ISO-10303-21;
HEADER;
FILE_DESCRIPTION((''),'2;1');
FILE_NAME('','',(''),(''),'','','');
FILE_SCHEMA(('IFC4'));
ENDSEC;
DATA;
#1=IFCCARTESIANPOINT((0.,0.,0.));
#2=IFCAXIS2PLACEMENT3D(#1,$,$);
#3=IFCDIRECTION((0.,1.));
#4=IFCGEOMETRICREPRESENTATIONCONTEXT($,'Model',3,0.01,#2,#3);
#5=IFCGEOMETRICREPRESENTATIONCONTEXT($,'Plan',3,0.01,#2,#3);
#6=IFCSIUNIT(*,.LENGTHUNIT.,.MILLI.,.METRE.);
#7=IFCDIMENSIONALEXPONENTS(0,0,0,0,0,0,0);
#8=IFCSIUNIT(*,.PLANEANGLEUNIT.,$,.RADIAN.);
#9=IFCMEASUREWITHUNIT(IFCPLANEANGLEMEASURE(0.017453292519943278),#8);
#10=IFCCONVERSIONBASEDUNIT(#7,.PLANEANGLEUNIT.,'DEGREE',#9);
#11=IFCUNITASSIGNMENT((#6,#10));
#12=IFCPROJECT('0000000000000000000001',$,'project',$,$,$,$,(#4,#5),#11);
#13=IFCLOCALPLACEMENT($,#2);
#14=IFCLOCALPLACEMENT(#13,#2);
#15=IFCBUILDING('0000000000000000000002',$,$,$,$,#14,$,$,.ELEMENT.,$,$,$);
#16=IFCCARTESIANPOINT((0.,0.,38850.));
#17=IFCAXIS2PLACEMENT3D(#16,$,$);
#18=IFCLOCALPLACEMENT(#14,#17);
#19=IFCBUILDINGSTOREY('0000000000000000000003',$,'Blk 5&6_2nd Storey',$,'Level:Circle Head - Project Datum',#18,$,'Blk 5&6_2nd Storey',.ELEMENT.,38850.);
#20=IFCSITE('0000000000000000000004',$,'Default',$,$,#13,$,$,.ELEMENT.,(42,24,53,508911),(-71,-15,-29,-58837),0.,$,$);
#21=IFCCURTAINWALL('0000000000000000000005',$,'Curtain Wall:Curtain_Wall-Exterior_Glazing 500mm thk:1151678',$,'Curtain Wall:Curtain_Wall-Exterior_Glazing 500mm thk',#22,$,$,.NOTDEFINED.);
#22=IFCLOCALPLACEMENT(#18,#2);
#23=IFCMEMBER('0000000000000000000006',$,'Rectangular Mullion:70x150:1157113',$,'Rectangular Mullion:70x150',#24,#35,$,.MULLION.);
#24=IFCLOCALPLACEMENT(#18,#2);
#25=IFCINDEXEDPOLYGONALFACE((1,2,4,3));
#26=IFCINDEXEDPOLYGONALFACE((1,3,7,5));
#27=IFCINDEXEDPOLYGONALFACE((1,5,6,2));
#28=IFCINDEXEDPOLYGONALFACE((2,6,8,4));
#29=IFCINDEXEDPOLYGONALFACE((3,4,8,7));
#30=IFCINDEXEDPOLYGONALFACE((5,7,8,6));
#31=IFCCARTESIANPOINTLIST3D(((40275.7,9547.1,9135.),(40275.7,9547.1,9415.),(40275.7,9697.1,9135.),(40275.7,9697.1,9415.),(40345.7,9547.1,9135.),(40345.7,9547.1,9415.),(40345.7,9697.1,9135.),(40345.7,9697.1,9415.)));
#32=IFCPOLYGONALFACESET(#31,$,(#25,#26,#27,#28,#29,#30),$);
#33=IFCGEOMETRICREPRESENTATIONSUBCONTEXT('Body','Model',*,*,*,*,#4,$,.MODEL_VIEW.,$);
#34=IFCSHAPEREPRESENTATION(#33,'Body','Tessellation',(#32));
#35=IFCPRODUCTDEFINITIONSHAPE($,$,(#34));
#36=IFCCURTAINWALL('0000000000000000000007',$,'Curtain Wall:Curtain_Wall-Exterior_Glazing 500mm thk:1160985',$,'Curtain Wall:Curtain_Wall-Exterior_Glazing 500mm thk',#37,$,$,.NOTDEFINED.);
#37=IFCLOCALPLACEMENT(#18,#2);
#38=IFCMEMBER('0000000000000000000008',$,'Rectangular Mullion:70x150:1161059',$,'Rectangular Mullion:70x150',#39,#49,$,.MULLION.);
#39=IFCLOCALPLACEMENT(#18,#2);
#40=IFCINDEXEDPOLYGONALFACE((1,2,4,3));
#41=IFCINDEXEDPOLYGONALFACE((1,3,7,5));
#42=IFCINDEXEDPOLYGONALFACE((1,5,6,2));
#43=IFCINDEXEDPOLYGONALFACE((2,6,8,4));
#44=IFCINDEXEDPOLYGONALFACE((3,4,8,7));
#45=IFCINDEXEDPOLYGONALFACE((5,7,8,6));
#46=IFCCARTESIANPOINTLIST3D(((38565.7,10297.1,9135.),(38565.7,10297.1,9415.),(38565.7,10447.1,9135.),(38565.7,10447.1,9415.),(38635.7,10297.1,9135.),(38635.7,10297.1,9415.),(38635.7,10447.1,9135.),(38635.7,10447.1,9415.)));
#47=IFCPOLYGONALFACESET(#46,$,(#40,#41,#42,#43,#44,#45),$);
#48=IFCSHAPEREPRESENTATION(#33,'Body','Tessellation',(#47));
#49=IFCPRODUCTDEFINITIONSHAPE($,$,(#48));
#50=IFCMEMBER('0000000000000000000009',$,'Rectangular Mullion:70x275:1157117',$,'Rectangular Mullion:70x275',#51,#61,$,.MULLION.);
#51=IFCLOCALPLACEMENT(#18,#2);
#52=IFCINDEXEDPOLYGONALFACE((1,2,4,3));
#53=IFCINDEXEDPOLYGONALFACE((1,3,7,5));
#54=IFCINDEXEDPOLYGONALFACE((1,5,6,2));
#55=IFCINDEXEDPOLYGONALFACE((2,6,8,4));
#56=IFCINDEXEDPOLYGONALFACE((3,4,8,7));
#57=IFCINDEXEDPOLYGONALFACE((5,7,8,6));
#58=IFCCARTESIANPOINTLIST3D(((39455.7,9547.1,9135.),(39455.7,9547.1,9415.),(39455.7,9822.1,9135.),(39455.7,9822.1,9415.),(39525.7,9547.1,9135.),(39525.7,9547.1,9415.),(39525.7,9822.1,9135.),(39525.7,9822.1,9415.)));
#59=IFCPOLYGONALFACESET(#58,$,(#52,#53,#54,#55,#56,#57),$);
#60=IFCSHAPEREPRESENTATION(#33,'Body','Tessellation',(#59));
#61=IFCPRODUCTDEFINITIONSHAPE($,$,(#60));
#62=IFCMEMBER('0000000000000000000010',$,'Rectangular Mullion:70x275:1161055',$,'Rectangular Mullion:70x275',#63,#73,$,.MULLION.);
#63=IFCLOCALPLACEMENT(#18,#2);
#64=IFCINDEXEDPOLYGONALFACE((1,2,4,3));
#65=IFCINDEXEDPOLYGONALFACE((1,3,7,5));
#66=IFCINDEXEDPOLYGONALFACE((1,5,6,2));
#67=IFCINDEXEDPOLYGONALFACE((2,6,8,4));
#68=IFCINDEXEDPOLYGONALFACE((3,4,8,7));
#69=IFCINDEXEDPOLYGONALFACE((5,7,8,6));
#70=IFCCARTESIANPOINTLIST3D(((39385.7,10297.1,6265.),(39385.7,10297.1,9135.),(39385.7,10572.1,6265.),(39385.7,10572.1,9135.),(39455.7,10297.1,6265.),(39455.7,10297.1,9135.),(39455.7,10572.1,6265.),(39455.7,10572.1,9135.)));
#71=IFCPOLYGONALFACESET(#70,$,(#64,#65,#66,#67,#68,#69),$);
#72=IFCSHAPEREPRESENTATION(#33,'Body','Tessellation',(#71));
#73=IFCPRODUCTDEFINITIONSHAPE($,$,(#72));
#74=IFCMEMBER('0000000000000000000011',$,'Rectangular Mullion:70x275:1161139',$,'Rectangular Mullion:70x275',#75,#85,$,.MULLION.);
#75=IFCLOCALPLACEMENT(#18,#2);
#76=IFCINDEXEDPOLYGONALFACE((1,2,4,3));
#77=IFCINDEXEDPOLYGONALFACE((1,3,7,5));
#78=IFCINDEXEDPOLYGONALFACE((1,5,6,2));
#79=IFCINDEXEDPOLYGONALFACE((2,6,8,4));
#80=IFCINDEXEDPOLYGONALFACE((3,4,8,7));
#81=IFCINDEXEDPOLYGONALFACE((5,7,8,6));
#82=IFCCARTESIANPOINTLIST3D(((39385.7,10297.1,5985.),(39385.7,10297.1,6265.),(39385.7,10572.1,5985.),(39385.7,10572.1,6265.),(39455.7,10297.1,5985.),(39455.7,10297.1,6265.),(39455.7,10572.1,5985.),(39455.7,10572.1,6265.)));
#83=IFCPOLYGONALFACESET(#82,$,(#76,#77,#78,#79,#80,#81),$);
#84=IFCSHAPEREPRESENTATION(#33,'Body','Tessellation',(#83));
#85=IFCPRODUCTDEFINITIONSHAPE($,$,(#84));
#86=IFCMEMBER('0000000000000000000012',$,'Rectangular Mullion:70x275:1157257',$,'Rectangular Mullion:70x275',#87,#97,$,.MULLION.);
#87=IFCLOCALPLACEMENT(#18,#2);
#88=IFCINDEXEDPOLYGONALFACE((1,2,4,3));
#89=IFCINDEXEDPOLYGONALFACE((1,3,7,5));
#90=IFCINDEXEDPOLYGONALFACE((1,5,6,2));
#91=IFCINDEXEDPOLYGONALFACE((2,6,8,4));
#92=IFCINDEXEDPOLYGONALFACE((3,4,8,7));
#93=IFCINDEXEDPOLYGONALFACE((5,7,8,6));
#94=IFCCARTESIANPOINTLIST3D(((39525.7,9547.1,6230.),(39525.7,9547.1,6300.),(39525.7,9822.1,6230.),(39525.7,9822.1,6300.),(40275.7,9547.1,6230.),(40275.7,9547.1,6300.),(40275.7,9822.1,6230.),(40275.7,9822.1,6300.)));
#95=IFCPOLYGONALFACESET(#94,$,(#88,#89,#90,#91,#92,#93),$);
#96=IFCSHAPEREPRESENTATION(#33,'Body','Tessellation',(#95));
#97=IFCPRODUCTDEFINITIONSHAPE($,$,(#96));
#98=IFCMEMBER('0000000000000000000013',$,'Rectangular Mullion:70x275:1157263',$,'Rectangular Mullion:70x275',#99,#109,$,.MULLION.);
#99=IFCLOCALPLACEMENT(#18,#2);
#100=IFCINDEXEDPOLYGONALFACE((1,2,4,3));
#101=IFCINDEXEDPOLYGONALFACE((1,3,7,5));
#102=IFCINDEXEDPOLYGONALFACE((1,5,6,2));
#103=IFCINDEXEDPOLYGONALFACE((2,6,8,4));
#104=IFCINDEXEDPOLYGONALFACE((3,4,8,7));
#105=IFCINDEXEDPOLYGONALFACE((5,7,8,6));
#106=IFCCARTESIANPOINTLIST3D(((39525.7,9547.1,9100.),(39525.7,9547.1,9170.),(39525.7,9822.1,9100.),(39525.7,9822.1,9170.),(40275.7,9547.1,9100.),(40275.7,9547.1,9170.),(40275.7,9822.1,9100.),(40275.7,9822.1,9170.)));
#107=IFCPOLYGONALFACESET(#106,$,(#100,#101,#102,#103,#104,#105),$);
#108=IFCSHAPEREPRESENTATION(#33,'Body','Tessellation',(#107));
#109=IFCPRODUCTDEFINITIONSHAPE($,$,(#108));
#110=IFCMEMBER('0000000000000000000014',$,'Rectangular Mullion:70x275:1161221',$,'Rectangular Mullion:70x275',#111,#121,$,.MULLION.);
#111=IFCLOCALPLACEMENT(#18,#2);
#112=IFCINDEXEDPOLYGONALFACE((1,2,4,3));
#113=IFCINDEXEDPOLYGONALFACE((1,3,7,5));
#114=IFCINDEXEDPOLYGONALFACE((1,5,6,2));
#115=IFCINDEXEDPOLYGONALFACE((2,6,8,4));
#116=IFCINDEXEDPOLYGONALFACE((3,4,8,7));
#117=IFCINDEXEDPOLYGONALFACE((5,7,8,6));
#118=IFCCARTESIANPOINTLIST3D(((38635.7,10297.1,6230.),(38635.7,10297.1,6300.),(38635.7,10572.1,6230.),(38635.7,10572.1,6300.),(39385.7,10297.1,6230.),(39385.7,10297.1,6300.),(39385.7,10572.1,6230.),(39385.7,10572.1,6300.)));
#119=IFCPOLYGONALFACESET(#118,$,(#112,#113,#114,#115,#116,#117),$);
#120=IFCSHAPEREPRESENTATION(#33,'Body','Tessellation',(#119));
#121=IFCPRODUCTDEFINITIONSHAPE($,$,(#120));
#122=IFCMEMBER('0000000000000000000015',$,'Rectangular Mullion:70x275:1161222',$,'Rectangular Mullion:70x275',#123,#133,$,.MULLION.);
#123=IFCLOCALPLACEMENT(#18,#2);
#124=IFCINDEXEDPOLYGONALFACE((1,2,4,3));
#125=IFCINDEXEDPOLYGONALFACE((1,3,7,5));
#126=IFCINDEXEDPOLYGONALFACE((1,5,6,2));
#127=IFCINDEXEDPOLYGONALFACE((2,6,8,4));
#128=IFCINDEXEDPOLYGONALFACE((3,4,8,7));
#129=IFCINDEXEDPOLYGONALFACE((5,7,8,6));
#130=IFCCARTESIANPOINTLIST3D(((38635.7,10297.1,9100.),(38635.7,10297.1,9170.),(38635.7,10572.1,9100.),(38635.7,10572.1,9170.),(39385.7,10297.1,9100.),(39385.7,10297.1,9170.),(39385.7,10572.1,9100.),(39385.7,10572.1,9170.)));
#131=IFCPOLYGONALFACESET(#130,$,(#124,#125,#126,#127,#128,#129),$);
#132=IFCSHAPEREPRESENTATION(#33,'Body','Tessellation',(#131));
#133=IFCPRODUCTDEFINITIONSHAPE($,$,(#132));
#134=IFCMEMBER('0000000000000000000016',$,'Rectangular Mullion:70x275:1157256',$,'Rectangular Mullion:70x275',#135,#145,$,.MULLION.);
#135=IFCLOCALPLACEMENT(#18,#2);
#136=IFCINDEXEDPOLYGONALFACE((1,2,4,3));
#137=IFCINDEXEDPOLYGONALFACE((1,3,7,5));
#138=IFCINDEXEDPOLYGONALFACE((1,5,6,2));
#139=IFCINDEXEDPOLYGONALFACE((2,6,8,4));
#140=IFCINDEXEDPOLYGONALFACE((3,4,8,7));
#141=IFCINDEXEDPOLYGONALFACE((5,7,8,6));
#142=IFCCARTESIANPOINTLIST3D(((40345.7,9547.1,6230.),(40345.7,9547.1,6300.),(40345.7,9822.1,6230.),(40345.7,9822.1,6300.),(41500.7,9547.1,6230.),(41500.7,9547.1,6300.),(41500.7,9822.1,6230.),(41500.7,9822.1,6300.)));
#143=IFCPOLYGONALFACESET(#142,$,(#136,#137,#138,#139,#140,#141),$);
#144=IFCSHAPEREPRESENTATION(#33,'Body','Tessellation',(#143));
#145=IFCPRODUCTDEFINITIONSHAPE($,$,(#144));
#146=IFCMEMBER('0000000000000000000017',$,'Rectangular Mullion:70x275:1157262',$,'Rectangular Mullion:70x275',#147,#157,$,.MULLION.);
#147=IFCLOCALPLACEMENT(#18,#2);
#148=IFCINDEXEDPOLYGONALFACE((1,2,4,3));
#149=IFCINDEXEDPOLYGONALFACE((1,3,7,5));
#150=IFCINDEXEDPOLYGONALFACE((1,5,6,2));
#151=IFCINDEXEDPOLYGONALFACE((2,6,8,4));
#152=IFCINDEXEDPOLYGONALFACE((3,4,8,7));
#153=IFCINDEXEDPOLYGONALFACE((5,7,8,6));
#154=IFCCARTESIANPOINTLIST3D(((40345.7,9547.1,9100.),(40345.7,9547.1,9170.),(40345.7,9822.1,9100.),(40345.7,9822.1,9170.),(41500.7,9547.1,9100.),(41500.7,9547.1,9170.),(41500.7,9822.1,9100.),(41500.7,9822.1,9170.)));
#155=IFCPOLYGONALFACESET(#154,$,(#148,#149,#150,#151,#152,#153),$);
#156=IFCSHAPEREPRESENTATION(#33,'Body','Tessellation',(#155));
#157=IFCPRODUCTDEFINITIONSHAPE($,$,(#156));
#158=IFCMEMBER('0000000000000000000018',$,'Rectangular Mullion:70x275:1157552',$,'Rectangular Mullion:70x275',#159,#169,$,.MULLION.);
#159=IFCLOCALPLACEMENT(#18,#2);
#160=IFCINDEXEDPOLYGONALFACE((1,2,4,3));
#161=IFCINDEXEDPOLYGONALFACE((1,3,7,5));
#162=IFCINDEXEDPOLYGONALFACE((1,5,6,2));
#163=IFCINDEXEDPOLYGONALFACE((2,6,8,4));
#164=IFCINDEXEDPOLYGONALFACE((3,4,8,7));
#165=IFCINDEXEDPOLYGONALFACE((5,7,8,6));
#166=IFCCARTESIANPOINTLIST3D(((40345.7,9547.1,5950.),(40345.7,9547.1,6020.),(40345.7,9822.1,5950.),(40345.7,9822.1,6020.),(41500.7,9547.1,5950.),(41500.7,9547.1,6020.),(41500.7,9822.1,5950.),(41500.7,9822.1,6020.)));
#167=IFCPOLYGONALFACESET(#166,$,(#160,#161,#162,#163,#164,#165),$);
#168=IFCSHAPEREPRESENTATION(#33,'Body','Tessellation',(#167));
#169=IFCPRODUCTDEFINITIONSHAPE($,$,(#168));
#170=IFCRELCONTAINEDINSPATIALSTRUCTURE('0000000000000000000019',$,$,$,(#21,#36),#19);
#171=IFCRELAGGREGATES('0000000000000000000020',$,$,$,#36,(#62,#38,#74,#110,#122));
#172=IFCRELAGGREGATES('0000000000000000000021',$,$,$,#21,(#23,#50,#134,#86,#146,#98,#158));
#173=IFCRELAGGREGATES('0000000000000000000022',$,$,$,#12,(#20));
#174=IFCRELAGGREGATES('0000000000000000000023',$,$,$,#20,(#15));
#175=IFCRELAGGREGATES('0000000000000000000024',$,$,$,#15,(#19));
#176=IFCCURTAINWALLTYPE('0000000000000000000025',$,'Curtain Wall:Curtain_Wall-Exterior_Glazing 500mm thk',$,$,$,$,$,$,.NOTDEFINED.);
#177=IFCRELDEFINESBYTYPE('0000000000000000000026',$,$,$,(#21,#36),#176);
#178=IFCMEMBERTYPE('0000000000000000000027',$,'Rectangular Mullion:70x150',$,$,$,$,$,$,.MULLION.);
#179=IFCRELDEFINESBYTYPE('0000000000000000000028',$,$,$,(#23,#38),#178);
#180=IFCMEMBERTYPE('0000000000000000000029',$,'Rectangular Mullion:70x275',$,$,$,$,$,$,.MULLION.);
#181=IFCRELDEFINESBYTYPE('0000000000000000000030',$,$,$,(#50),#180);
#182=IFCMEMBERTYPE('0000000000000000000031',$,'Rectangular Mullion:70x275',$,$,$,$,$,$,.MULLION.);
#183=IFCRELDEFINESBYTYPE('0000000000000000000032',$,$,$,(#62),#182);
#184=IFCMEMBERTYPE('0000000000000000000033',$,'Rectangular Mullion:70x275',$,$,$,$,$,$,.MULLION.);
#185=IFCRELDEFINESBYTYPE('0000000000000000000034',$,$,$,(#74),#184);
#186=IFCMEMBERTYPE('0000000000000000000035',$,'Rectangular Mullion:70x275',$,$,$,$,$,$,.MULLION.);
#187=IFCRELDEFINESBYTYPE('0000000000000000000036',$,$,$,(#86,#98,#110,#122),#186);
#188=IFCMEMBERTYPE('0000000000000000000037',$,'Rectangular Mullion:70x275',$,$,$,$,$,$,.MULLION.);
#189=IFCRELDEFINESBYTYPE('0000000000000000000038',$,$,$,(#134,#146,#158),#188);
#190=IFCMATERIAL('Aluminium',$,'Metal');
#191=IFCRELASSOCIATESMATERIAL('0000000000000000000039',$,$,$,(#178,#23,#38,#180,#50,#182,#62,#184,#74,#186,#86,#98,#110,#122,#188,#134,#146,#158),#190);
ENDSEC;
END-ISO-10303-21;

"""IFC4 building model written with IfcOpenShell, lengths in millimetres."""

from ifc_helpers import new_model, entity, si_unit, converted_unit, direction, frame, origin, place, context, subcontext, project, spatial, indexed_curve, outline, extrude, source, transform, mapped, material, type_object, type_shapes, element, aggregate, save


model = new_model("IFC4")

# Units and contexts
model_context = context("Model", 3, precision=0.01, world=origin(), true_north=direction((0.0, 1.0)))
plan_context = context("Plan", 3, precision=0.01, world=origin(), true_north=direction((0.0, 1.0)))
body_context = subcontext(model_context, "Body", "Model", "MODEL_VIEW")
ifc_project = project(units=[si_unit("LENGTHUNIT", "METRE", prefix="MILLI"), converted_unit("PLANEANGLEUNIT", "DEGREE", entity("IfcPlaneAngleMeasure", 0.017453292519943278), si_unit("PLANEANGLEUNIT", "RADIAN"), dimensions=[0, 0, 0, 0, 0, 0, 0])], contexts=[model_context, plan_context])

# Site, building, storey
site_placement = place(None, origin())
site = spatial("IfcSite", under=ifc_project, at=site_placement, Name="Default", CompositionType="ELEMENT", RefLatitude=(42, 24, 53, 508911), RefLongitude=(-71, -15, -29, -58837), RefElevation=0.0)
building_placement = place(site_placement, origin())
building = spatial("IfcBuilding", under=site, at=building_placement, CompositionType="ELEMENT")
storey_placement = place(building_placement, frame((0.0, 0.0, 38850.0)))
storey = spatial("IfcBuildingStorey", under=building, at=storey_placement, Name="Blk 5&6_2nd Storey", ObjectType="Level:Circle Head - Project Datum", LongName="Blk 5&6_2nd Storey", CompositionType="ELEMENT", Elevation=38850.0)

# Curtain walls, members
curtain_wall_type = type_object("IfcCurtainWallType", Name="Curtain Wall:Curtain_Wall-Exterior_Glazing 500mm thk", PredefinedType="NOTDEFINED")
curtain_wall_1_placement = place(storey_placement, frame((0.0, 0.0, -38850.0)))
curtain_wall_1 = element("IfcCurtainWall", 1, at=curtain_wall_1_placement, inside=storey, type_object=curtain_wall_type, Name="Curtain Wall:Curtain_Wall-Exterior_Glazing 500mm thk:1151678", ObjectType="Curtain Wall:Curtain_Wall-Exterior_Glazing 500mm thk", PredefinedType="NOTDEFINED")
ifc_material_1 = material(Name="Aluminium", Category="Metal")
member_type_1 = type_object("IfcMemberType", Name="Rectangular Mullion:70x150", PredefinedType="MULLION", material=ifc_material_1)
shared_shape_1 = source(origin(), body_context, "Body", "SweptSolid", [
    extrude(outline(indexed_curve([(-35.0, -75.0), (35.0, -75.0), (35.0, 75.0), (-35.0, 75.0), (-35.0, -75.0)], self_intersect=False)), frame((0.0, -200.0, -280.0), z_axis=(0.0, 0.0, 1.0), x_axis=(-1.0, 0.0, 0.0)), (0.0, 0.0, 1.0), 280.0),
])
type_shapes(member_type_1, [shared_shape_1])
member_1_placement = place(curtain_wall_1_placement, frame((40310.7, 9822.1, 47985.0), z_axis=(0.0, 0.0, -1.0), x_axis=(-1.0, 0.0, 0.0)))
member_1 = element("IfcMember", 2, at=member_1_placement, type_object=member_type_1, material=ifc_material_1, Name="Rectangular Mullion:70x150:1157113", ObjectType="Rectangular Mullion:70x150", PredefinedType="MULLION", context=body_context, shape_type="MappedRepresentation", body=[
    mapped(shared_shape_1, transform((0.0, 0.0, 0.0), scale=1.0)),
])
curtain_wall_2_placement = place(storey_placement, frame((0.0, 0.0, -38850.0)))
curtain_wall_2 = element("IfcCurtainWall", 3, at=curtain_wall_2_placement, inside=storey, type_object=curtain_wall_type, Name="Curtain Wall:Curtain_Wall-Exterior_Glazing 500mm thk:1160985", ObjectType="Curtain Wall:Curtain_Wall-Exterior_Glazing 500mm thk", PredefinedType="NOTDEFINED")
member_2_placement = place(curtain_wall_2_placement, frame((38600.7, 10572.1, 47985.0), z_axis=(0.0, 0.0, -1.0), x_axis=(-1.0, 0.0, 0.0)))
member_2 = element("IfcMember", 4, at=member_2_placement, type_object=member_type_1, material=ifc_material_1, Name="Rectangular Mullion:70x150:1161059", ObjectType="Rectangular Mullion:70x150", PredefinedType="MULLION", context=body_context, shape_type="MappedRepresentation", body=[
    mapped(shared_shape_1, transform((0.0, 0.0, 0.0), scale=1.0)),
])

# Members
member_type_2 = type_object("IfcMemberType", Name="Rectangular Mullion:70x275", PredefinedType="MULLION", material=ifc_material_1)
shared_shape_2 = source(origin(), body_context, "Body", "SweptSolid", [
    extrude(outline(indexed_curve([(-35.0, -137.5), (35.0, -137.5), (35.0, 137.5), (-35.0, 137.5), (-35.0, -137.5)], self_intersect=False)), frame((-35.0, -137.5, -280.0), z_axis=(0.0, 0.0, 1.0), x_axis=(-1.0, 0.0, 0.0)), (0.0, 0.0, 1.0), 280.0),
])
type_shapes(member_type_2, [shared_shape_2])
member_3_placement = place(curtain_wall_1_placement, frame((39455.7, 9822.1, 47985.0), z_axis=(0.0, 0.0, -1.0), x_axis=(-1.0, 0.0, 0.0)))
member_3 = element("IfcMember", 5, at=member_3_placement, type_object=member_type_2, material=ifc_material_1, Name="Rectangular Mullion:70x275:1157117", ObjectType="Rectangular Mullion:70x275", PredefinedType="MULLION", context=body_context, shape_type="MappedRepresentation", body=[
    mapped(shared_shape_2, transform((0.0, 0.0, 0.0), scale=1.0)),
])
member_type_3 = type_object("IfcMemberType", Name="Rectangular Mullion:70x275", PredefinedType="MULLION", material=ifc_material_1)
shared_shape_3 = source(origin(), body_context, "Body", "SweptSolid", [
    extrude(outline(indexed_curve([(-35.0, -137.5), (35.0, -137.5), (35.0, 137.5), (-35.0, 137.5), (-35.0, -137.5)], self_intersect=False)), frame((-35.0, -137.5, -2870.0), z_axis=(0.0, 0.0, 1.0), x_axis=(-1.0, 0.0, 0.0)), (0.0, 0.0, 1.0), 2870.0),
])
type_shapes(member_type_3, [shared_shape_3])
member_4_placement = place(curtain_wall_2_placement, frame((39455.7, 10572.1, 47985.0)))
member_4 = element("IfcMember", 6, at=member_4_placement, type_object=member_type_3, material=ifc_material_1, Name="Rectangular Mullion:70x275:1161055", ObjectType="Rectangular Mullion:70x275", PredefinedType="MULLION", context=body_context, shape_type="MappedRepresentation", body=[
    mapped(shared_shape_3, transform((0.0, 0.0, 0.0), scale=1.0)),
])
member_type_4 = type_object("IfcMemberType", Name="Rectangular Mullion:70x275", PredefinedType="MULLION", material=ifc_material_1)
shared_shape_4 = source(origin(), body_context, "Body", "SweptSolid", [
    extrude(outline(indexed_curve([(-35.0, -137.5), (35.0, -137.5), (35.0, 137.5), (-35.0, 137.5), (-35.0, -137.5)], self_intersect=False)), frame((-35.0, -137.5, -280.0), z_axis=(0.0, 0.0, 1.0), x_axis=(-1.0, 0.0, 0.0)), (0.0, 0.0, 1.0), 280.0),
])
type_shapes(member_type_4, [shared_shape_4])
member_5_placement = place(curtain_wall_2_placement, frame((39455.7, 10572.1, 45115.0)))
member_5 = element("IfcMember", 7, at=member_5_placement, type_object=member_type_4, material=ifc_material_1, Name="Rectangular Mullion:70x275:1161139", ObjectType="Rectangular Mullion:70x275", PredefinedType="MULLION", context=body_context, shape_type="MappedRepresentation", body=[
    mapped(shared_shape_4, transform((0.0, 0.0, 0.0), scale=1.0)),
])
member_type_5 = type_object("IfcMemberType", Name="Rectangular Mullion:70x275", PredefinedType="MULLION", material=ifc_material_1)
shared_shape_5 = source(origin(), body_context, "Body", "SweptSolid", [
    extrude(outline(indexed_curve([(-35.0, -137.5), (35.0, -137.5), (35.0, 137.5), (-35.0, 137.5), (-35.0, -137.5)], self_intersect=False)), frame((0.0, -137.5, -750.0), z_axis=(0.0, 0.0, 1.0), x_axis=(-1.0, 0.0, 0.0)), (0.0, 0.0, 1.0), 750.0),
])
type_shapes(member_type_5, [shared_shape_5])
member_6_placement = place(curtain_wall_1_placement, frame((39525.7, 9822.1, 45115.0), z_axis=(-1.0, 0.0, 0.0), x_axis=(0.0, 0.0, 1.0)))
member_6 = element("IfcMember", 8, at=member_6_placement, type_object=member_type_5, material=ifc_material_1, Name="Rectangular Mullion:70x275:1157257", ObjectType="Rectangular Mullion:70x275", PredefinedType="MULLION", context=body_context, shape_type="MappedRepresentation", body=[
    mapped(shared_shape_5, transform((0.0, 0.0, 0.0), scale=1.0)),
])
member_7_placement = place(curtain_wall_1_placement, frame((39525.7, 9822.1, 47985.0), z_axis=(-1.0, 0.0, 0.0), x_axis=(0.0, 0.0, 1.0)))
member_7 = element("IfcMember", 9, at=member_7_placement, type_object=member_type_5, material=ifc_material_1, Name="Rectangular Mullion:70x275:1157263", ObjectType="Rectangular Mullion:70x275", PredefinedType="MULLION", context=body_context, shape_type="MappedRepresentation", body=[
    mapped(shared_shape_5, transform((0.0, 0.0, 0.0), scale=1.0)),
])
member_8_placement = place(curtain_wall_2_placement, frame((38635.7, 10572.1, 45115.0), z_axis=(-1.0, 0.0, 0.0), x_axis=(0.0, 0.0, 1.0)))
member_8 = element("IfcMember", 10, at=member_8_placement, type_object=member_type_5, material=ifc_material_1, Name="Rectangular Mullion:70x275:1161221", ObjectType="Rectangular Mullion:70x275", PredefinedType="MULLION", context=body_context, shape_type="MappedRepresentation", body=[
    mapped(shared_shape_5, transform((0.0, 0.0, 0.0), scale=1.0)),
])
member_9_placement = place(curtain_wall_2_placement, frame((38635.7, 10572.1, 47985.0), z_axis=(-1.0, 0.0, 0.0), x_axis=(0.0, 0.0, 1.0)))
member_9 = element("IfcMember", 11, at=member_9_placement, type_object=member_type_5, material=ifc_material_1, Name="Rectangular Mullion:70x275:1161222", ObjectType="Rectangular Mullion:70x275", PredefinedType="MULLION", context=body_context, shape_type="MappedRepresentation", body=[
    mapped(shared_shape_5, transform((0.0, 0.0, 0.0), scale=1.0)),
])
member_type_6 = type_object("IfcMemberType", Name="Rectangular Mullion:70x275", PredefinedType="MULLION", material=ifc_material_1)
shared_shape_6 = source(origin(), body_context, "Body", "SweptSolid", [
    extrude(outline(indexed_curve([(-35.0, -137.5), (35.0, -137.5), (35.0, 137.5), (-35.0, 137.5), (-35.0, -137.5)], self_intersect=False)), frame((0.0, -137.5, -1155.0), z_axis=(0.0, 0.0, 1.0), x_axis=(-1.0, 0.0, 0.0)), (0.0, 0.0, 1.0), 1155.0),
])
type_shapes(member_type_6, [shared_shape_6])
member_10_placement = place(curtain_wall_1_placement, frame((40345.7, 9822.1, 45115.0), z_axis=(-1.0, 0.0, 0.0), x_axis=(0.0, 0.0, 1.0)))
member_10 = element("IfcMember", 12, at=member_10_placement, type_object=member_type_6, material=ifc_material_1, Name="Rectangular Mullion:70x275:1157256", ObjectType="Rectangular Mullion:70x275", PredefinedType="MULLION", context=body_context, shape_type="MappedRepresentation", body=[
    mapped(shared_shape_6, transform((0.0, 0.0, 0.0), scale=1.0)),
])
member_11_placement = place(curtain_wall_1_placement, frame((40345.7, 9822.1, 47985.0), z_axis=(-1.0, 0.0, 0.0), x_axis=(0.0, 0.0, 1.0)))
member_11 = element("IfcMember", 13, at=member_11_placement, type_object=member_type_6, material=ifc_material_1, Name="Rectangular Mullion:70x275:1157262", ObjectType="Rectangular Mullion:70x275", PredefinedType="MULLION", context=body_context, shape_type="MappedRepresentation", body=[
    mapped(shared_shape_6, transform((0.0, 0.0, 0.0), scale=1.0)),
])
member_12_placement = place(curtain_wall_1_placement, frame((40345.7, 9822.1, 44835.0), z_axis=(-1.0, 0.0, 0.0), x_axis=(0.0, 0.0, 1.0)))
member_12 = element("IfcMember", 14, at=member_12_placement, type_object=member_type_6, material=ifc_material_1, Name="Rectangular Mullion:70x275:1157552", ObjectType="Rectangular Mullion:70x275", PredefinedType="MULLION", context=body_context, shape_type="MappedRepresentation", body=[
    mapped(shared_shape_6, transform((0.0, 0.0, 0.0), scale=1.0)),
])

aggregate(curtain_wall_2, [member_4, member_2, member_5, member_8, member_9])
aggregate(curtain_wall_1, [member_1, member_3, member_10, member_6, member_11, member_7, member_12])

save(model, "model.ifc")
